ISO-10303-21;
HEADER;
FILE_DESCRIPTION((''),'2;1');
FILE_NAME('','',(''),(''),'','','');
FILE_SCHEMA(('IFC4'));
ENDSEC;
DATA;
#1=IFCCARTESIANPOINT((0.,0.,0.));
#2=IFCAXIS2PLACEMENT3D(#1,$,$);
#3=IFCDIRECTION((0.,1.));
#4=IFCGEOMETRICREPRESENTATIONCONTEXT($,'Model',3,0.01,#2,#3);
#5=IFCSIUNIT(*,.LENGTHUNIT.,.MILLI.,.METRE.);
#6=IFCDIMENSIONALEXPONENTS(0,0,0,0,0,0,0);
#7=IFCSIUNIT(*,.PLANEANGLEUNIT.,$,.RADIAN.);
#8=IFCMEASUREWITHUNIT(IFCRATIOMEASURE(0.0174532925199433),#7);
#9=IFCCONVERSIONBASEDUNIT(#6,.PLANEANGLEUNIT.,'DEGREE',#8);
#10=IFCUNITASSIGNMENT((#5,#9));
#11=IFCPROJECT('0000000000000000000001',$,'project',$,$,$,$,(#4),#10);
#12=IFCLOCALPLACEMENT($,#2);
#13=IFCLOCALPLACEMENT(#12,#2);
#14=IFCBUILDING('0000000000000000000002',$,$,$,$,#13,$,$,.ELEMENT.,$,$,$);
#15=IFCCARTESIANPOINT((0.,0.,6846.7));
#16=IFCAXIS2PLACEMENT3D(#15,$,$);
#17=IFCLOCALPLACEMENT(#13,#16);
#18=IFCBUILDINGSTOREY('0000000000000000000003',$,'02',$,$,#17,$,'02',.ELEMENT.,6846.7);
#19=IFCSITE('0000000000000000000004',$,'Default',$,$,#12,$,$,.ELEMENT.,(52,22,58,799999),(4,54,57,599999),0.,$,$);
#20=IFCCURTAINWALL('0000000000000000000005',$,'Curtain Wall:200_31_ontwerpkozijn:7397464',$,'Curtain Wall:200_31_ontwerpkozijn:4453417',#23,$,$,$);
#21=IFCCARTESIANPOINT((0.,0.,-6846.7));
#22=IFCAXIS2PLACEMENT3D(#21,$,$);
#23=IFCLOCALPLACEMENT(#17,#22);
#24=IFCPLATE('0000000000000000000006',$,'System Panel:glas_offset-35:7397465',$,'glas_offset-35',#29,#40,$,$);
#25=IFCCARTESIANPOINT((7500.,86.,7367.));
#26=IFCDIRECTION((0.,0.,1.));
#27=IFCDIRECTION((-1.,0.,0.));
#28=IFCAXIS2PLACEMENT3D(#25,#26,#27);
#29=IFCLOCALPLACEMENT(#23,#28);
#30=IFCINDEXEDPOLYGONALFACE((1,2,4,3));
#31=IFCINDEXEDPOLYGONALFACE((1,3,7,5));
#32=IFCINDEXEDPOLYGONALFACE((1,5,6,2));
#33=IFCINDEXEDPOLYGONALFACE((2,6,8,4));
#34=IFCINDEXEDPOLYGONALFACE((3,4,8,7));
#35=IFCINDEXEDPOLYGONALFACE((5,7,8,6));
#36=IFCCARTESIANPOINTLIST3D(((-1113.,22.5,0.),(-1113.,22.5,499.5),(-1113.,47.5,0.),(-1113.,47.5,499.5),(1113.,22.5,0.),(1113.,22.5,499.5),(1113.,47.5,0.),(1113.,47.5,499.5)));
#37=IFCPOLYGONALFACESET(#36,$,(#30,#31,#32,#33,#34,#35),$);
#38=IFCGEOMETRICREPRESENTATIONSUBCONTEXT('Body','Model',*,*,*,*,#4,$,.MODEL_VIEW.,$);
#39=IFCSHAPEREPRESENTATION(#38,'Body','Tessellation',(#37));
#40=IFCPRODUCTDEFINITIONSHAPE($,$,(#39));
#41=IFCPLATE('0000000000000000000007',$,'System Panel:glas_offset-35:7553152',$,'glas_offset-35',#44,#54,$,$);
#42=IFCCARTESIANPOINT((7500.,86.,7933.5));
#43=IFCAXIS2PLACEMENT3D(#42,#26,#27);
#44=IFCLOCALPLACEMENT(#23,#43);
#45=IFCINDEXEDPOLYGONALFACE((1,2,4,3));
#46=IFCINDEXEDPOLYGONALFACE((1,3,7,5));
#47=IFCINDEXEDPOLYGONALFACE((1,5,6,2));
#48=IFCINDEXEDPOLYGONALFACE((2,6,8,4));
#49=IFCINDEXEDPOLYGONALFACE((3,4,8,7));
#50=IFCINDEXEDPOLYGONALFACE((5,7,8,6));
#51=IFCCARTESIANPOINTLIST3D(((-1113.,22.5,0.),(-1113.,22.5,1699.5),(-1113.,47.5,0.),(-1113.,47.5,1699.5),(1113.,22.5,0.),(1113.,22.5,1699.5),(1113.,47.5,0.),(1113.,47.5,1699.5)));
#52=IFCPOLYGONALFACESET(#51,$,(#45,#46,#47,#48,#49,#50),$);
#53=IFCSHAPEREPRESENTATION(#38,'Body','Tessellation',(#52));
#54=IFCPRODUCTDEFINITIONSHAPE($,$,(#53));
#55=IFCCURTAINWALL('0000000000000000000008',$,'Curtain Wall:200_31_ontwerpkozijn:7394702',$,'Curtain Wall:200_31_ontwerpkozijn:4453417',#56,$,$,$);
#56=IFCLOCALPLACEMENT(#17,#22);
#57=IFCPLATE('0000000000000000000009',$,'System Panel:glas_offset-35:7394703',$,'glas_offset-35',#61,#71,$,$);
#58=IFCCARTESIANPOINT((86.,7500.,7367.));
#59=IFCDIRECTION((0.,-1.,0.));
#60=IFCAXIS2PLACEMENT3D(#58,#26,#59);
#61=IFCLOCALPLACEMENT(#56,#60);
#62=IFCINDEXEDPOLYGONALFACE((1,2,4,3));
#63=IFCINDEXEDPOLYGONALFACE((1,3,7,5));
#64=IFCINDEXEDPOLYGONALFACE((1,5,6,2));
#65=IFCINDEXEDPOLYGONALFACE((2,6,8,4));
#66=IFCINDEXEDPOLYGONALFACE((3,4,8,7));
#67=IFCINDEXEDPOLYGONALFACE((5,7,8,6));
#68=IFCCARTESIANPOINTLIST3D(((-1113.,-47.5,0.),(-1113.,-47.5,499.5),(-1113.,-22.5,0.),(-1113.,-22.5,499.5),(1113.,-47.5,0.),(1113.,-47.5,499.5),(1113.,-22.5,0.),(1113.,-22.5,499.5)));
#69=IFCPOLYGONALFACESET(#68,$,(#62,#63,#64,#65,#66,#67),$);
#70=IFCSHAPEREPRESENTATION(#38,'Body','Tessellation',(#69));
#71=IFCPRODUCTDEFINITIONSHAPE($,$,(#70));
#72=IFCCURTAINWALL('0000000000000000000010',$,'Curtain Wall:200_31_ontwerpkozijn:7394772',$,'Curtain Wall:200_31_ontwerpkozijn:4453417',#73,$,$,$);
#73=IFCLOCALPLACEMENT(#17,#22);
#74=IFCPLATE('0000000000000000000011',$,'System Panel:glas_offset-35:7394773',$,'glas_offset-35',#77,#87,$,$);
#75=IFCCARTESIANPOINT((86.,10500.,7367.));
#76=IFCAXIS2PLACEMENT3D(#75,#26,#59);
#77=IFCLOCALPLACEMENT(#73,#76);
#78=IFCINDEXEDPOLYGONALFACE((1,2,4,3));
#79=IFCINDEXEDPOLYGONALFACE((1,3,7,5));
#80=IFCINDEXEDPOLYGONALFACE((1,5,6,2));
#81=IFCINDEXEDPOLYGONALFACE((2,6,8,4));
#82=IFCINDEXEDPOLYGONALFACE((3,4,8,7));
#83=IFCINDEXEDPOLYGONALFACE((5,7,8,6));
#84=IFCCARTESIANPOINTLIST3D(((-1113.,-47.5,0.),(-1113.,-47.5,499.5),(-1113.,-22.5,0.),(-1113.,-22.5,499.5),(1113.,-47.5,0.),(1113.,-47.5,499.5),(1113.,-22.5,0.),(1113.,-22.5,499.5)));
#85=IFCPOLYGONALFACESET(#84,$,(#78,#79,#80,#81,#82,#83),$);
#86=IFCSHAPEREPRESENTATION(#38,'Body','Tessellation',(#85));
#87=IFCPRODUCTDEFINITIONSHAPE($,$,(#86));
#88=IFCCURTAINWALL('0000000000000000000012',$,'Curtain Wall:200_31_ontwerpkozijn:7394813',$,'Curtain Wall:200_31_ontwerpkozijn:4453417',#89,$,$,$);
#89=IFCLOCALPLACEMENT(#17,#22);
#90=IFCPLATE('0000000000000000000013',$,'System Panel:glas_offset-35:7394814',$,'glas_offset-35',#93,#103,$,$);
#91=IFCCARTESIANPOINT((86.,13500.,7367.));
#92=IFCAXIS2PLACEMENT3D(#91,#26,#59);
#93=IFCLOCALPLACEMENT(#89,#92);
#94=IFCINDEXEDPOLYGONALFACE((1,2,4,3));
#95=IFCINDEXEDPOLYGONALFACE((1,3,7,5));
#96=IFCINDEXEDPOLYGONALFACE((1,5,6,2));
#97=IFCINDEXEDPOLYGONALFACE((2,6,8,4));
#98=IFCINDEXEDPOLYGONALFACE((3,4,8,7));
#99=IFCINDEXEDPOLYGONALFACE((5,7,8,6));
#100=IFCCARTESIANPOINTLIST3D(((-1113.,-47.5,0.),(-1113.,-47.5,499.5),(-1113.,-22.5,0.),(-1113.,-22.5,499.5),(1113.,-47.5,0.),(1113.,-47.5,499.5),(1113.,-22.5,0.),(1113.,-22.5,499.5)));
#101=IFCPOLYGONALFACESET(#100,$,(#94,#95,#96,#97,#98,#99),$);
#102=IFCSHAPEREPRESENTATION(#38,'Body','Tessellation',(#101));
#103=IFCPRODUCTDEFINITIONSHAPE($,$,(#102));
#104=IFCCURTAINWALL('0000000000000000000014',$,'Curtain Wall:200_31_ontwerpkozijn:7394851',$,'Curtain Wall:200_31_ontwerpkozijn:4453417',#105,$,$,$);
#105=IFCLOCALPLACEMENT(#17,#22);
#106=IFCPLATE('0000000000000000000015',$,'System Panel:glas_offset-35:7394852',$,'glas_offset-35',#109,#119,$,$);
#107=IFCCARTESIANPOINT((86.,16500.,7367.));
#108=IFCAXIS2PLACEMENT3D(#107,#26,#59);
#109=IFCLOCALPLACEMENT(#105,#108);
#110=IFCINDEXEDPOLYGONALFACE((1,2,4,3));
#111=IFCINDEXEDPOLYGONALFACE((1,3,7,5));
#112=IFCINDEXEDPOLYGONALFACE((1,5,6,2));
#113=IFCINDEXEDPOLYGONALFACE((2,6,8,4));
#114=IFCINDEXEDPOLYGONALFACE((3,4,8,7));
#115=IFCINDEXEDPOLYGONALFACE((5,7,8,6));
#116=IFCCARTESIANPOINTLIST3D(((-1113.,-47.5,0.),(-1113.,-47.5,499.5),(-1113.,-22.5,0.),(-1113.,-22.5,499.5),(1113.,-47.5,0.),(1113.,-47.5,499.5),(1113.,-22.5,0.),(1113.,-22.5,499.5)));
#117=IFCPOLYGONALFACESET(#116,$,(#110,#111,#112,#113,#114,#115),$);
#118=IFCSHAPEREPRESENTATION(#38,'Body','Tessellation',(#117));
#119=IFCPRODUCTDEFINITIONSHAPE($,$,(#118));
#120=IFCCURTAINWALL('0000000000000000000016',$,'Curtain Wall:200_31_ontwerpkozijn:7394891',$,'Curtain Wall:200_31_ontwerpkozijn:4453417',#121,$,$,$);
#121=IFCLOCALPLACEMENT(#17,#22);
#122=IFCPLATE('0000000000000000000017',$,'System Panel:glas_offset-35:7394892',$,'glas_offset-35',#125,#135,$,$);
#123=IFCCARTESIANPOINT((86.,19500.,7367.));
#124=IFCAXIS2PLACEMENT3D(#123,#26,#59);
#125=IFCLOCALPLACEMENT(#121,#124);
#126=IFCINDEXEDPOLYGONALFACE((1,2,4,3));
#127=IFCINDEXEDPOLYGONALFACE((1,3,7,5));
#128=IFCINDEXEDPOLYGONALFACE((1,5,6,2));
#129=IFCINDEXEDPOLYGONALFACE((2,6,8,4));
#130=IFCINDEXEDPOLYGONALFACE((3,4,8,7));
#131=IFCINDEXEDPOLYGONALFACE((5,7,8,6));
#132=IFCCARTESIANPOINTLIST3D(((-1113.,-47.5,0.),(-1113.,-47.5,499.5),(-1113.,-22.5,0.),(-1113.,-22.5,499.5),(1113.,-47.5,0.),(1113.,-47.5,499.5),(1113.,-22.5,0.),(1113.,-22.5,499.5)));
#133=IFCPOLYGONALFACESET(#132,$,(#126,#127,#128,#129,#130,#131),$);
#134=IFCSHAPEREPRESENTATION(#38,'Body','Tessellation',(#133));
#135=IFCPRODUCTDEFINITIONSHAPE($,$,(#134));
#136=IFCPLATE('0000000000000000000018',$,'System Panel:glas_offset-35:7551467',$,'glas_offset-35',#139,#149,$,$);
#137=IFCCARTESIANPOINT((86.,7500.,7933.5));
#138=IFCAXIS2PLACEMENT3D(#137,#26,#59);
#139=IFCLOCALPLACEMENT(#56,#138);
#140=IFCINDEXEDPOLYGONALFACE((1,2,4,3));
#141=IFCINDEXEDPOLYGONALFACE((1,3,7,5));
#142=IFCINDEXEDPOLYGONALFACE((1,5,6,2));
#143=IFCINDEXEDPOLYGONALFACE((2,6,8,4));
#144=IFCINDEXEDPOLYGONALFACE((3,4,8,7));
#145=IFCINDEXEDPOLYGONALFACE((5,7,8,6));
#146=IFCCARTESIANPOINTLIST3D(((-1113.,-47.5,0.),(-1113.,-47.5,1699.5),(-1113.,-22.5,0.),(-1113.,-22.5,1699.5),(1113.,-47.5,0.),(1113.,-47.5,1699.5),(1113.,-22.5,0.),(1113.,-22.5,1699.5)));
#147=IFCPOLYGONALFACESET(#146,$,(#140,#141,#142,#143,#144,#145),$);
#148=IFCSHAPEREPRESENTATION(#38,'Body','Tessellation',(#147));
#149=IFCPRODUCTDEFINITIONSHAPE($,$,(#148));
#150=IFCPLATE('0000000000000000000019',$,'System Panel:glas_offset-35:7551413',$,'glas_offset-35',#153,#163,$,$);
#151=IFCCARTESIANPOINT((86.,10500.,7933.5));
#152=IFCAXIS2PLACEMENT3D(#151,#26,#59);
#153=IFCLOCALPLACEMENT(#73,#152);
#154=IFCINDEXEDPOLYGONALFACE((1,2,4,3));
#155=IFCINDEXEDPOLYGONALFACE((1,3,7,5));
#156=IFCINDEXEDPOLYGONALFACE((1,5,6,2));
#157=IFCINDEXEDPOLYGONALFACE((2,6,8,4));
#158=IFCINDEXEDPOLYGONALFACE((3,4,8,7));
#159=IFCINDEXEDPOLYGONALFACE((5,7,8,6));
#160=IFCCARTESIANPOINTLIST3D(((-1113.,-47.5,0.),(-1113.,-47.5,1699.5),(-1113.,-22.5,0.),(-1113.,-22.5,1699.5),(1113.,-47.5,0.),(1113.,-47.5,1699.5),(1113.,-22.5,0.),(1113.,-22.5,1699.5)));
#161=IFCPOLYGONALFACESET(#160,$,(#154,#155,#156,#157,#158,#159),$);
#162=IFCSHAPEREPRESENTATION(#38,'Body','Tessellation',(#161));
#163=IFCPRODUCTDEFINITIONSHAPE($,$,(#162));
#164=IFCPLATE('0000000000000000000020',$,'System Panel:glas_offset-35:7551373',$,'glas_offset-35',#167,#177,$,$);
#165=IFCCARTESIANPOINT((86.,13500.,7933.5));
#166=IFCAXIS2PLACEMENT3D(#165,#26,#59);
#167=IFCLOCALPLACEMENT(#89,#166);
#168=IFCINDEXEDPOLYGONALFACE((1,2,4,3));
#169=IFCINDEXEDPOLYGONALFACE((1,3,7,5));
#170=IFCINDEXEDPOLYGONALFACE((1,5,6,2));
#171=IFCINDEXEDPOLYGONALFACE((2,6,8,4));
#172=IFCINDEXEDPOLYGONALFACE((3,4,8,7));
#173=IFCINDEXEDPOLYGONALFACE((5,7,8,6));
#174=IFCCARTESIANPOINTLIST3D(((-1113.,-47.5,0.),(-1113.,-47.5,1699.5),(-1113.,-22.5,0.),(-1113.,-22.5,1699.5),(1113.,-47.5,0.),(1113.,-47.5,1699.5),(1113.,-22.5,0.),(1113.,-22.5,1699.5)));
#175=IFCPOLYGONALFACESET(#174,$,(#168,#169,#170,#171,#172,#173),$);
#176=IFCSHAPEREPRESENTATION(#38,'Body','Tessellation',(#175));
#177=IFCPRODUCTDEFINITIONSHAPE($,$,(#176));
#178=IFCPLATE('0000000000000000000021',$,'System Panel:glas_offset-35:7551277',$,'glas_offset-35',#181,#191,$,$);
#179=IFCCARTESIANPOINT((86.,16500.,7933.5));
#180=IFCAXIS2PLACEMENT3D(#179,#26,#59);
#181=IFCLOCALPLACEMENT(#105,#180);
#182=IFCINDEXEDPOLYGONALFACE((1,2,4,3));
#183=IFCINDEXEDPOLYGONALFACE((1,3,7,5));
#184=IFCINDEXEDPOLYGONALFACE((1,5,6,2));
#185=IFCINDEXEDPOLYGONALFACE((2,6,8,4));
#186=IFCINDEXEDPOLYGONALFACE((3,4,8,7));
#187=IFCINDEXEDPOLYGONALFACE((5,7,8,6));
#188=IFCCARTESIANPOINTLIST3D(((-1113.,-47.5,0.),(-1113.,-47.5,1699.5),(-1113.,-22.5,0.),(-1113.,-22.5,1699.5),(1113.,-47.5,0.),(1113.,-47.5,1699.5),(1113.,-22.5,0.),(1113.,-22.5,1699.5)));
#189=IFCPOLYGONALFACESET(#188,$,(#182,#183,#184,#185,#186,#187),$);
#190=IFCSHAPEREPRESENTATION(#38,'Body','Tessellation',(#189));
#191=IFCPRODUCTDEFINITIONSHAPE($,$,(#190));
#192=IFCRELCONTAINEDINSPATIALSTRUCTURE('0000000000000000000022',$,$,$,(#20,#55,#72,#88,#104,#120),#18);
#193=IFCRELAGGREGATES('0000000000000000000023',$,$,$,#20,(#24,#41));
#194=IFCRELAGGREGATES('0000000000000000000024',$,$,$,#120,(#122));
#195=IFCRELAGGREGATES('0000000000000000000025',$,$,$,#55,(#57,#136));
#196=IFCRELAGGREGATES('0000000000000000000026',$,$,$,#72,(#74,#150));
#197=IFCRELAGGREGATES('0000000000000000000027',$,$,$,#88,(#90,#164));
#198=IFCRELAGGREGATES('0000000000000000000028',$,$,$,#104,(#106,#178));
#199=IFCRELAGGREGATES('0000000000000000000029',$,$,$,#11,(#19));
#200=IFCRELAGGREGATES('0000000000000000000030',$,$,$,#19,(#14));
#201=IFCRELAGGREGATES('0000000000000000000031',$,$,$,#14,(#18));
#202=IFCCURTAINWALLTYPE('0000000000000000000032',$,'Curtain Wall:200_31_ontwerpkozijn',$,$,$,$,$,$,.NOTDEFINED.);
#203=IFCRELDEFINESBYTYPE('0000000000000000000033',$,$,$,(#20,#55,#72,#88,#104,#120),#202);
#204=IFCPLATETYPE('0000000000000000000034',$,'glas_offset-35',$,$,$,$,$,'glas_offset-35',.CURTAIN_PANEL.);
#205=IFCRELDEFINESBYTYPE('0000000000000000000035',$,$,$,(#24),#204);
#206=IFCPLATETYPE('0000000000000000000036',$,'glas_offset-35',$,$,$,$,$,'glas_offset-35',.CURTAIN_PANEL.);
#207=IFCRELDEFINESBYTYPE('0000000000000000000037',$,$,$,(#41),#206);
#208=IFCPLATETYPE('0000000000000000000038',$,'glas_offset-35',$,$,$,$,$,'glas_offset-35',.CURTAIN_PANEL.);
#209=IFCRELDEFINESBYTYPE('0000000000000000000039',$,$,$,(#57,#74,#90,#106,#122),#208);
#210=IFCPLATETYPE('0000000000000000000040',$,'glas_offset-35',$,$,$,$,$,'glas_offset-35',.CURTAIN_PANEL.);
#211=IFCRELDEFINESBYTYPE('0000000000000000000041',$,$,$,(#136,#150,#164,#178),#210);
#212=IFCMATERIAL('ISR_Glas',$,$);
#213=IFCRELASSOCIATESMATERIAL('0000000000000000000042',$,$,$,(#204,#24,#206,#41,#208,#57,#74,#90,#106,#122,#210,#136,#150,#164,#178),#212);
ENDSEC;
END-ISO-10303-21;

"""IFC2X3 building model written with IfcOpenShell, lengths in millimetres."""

from ifc_helpers import new_model, entity, si_unit, converted_unit, direction, frame, frame_2d, origin, origin_2d_with_axis, place, context, subcontext, project, spatial, rectangle, extrude, source, transform, mapped, material, type_object, type_shapes, element, aggregate, save


model = new_model("IFC2X3")

# Units and contexts
model_context = context("Model", 3, precision=0.01, world=origin(), true_north=direction((0.0, 1.0)))
body_context = subcontext(model_context, "Body", "Model", "MODEL_VIEW")
ifc_project = project(units=[si_unit("LENGTHUNIT", "METRE", prefix="MILLI"), converted_unit("PLANEANGLEUNIT", "DEGREE", entity("IfcRatioMeasure", 0.0174532925199433), si_unit("PLANEANGLEUNIT", "RADIAN"), dimensions=[0, 0, 0, 0, 0, 0, 0])], contexts=[model_context])

# Site, building, storey
site_placement = place(None, origin())
site = spatial("IfcSite", under=ifc_project, at=site_placement, Name="Default", CompositionType="ELEMENT", RefLatitude=(52, 22, 58, 799999), RefLongitude=(4, 54, 57, 599999), RefElevation=0.0)
building_placement = place(site_placement, origin())
building = spatial("IfcBuilding", under=site, at=building_placement, CompositionType="ELEMENT")
storey_placement = place(building_placement, frame((0.0, 0.0, 6846.7)))
storey = spatial("IfcBuildingStorey", under=building, at=storey_placement, Name="02", LongName="02", CompositionType="ELEMENT", Elevation=6846.7)

# Curtain wall, plates
curtain_wall_type = type_object("IfcCurtainWallType", Name="Curtain Wall:200_31_ontwerpkozijn", PredefinedType="NOTDEFINED")
curtain_wall_1_placement = place(storey_placement, frame((0.0, 0.0, -6846.7)))
curtain_wall_1 = element("IfcCurtainWall", 1, at=curtain_wall_1_placement, inside=storey, type_object=curtain_wall_type, Name="Curtain Wall:200_31_ontwerpkozijn:7397464", ObjectType="Curtain Wall:200_31_ontwerpkozijn:4453417")
ifc_material_1 = material(Name="ISR_Glas")
plate_type_1 = type_object("IfcPlateType", Name="glas_offset-35", ElementType="glas_offset-35", PredefinedType="CURTAIN_PANEL", material=ifc_material_1)
shared_shape_1 = source(origin(), body_context, "Body", "SweptSolid", [
    extrude(rectangle(XDim=25.0, YDim=2226.0, at=origin_2d_with_axis()), frame((0.0, 35.0, 0.0), z_axis=(0.0, 0.0, 1.0), x_axis=(0.0, 1.0, 0.0)), (0.0, 0.0, 1.0), 499.5),
])
type_shapes(plate_type_1, [shared_shape_1])
plate_1_placement = place(curtain_wall_1_placement, frame((7500.0, 86.0, 7367.0), z_axis=(0.0, 0.0, 1.0), x_axis=(-1.0, 0.0, 0.0)))
plate_1 = element("IfcPlate", 2, at=plate_1_placement, type_object=plate_type_1, material=ifc_material_1, Name="System Panel:glas_offset-35:7397465", ObjectType="glas_offset-35", context=body_context, shape_type="MappedRepresentation", body=[
    mapped(shared_shape_1, transform((0.0, 0.0, 0.0), scale=1.0)),
])
plate_type_2 = type_object("IfcPlateType", Name="glas_offset-35", ElementType="glas_offset-35", PredefinedType="CURTAIN_PANEL", material=ifc_material_1)
shared_shape_2 = source(origin(), body_context, "Body", "SweptSolid", [
    extrude(rectangle(XDim=25.0, YDim=2226.0, at=origin_2d_with_axis()), frame((0.0, 35.0, 0.0), z_axis=(0.0, 0.0, 1.0), x_axis=(0.0, 1.0, 0.0)), (0.0, 0.0, 1.0), 1699.5),
])
type_shapes(plate_type_2, [shared_shape_2])
plate_2_placement = place(curtain_wall_1_placement, frame((7500.0, 86.0, 7933.5), z_axis=(0.0, 0.0, 1.0), x_axis=(-1.0, 0.0, 0.0)))
plate_2 = element("IfcPlate", 3, at=plate_2_placement, type_object=plate_type_2, material=ifc_material_1, Name="System Panel:glas_offset-35:7553152", ObjectType="glas_offset-35", context=body_context, shape_type="MappedRepresentation", body=[
    mapped(shared_shape_2, transform((0.0, 0.0, 0.0), scale=1.0)),
])
aggregate(curtain_wall_1, [plate_1, plate_2])

# Curtain walls, plates
curtain_wall_2_placement = place(storey_placement, frame((0.0, 0.0, -6846.7)))
curtain_wall_2 = element("IfcCurtainWall", 4, at=curtain_wall_2_placement, inside=storey, type_object=curtain_wall_type, Name="Curtain Wall:200_31_ontwerpkozijn:7394702", ObjectType="Curtain Wall:200_31_ontwerpkozijn:4453417")
plate_type_3 = type_object("IfcPlateType", Name="glas_offset-35", ElementType="glas_offset-35", PredefinedType="CURTAIN_PANEL", material=ifc_material_1)
shared_shape_3 = source(origin(), body_context, "Body", "SweptSolid", [
    extrude(rectangle(XDim=25.0, YDim=2226.0, at=frame_2d((0.0, 0.0), x_axis=(1.0, 0.0))), frame((0.0, -35.0, 0.0), z_axis=(0.0, 0.0, 1.0), x_axis=(0.0, 1.0, 0.0)), (0.0, 0.0, 1.0), 499.5),
])
type_shapes(plate_type_3, [shared_shape_3])
plate_3_placement = place(curtain_wall_2_placement, frame((86.0, 7500.0, 7367.0), z_axis=(0.0, 0.0, 1.0), x_axis=(0.0, -1.0, 0.0)))
plate_3 = element("IfcPlate", 5, at=plate_3_placement, type_object=plate_type_3, material=ifc_material_1, Name="System Panel:glas_offset-35:7394703", ObjectType="glas_offset-35", context=body_context, shape_type="MappedRepresentation", body=[
    mapped(shared_shape_3, transform((0.0, 0.0, 0.0), scale=1.0)),
])
curtain_wall_3_placement = place(storey_placement, frame((0.0, 0.0, -6846.7)))
curtain_wall_3 = element("IfcCurtainWall", 6, at=curtain_wall_3_placement, inside=storey, type_object=curtain_wall_type, Name="Curtain Wall:200_31_ontwerpkozijn:7394772", ObjectType="Curtain Wall:200_31_ontwerpkozijn:4453417")
plate_4_placement = place(curtain_wall_3_placement, frame((86.0, 10500.0, 7367.0), z_axis=(0.0, 0.0, 1.0), x_axis=(0.0, -1.0, 0.0)))
plate_4 = element("IfcPlate", 7, at=plate_4_placement, type_object=plate_type_3, material=ifc_material_1, Name="System Panel:glas_offset-35:7394773", ObjectType="glas_offset-35", context=body_context, shape_type="MappedRepresentation", body=[
    mapped(shared_shape_3, transform((0.0, 0.0, 0.0), scale=1.0)),
])
curtain_wall_4_placement = place(storey_placement, frame((0.0, 0.0, -6846.7)))
curtain_wall_4 = element("IfcCurtainWall", 8, at=curtain_wall_4_placement, inside=storey, type_object=curtain_wall_type, Name="Curtain Wall:200_31_ontwerpkozijn:7394813", ObjectType="Curtain Wall:200_31_ontwerpkozijn:4453417")
plate_5_placement = place(curtain_wall_4_placement, frame((86.0, 13500.0, 7367.0), z_axis=(0.0, 0.0, 1.0), x_axis=(0.0, -1.0, 0.0)))
plate_5 = element("IfcPlate", 9, at=plate_5_placement, type_object=plate_type_3, material=ifc_material_1, Name="System Panel:glas_offset-35:7394814", ObjectType="glas_offset-35", context=body_context, shape_type="MappedRepresentation", body=[
    mapped(shared_shape_3, transform((0.0, 0.0, 0.0), scale=1.0)),
])
curtain_wall_5_placement = place(storey_placement, frame((0.0, 0.0, -6846.7)))
curtain_wall_5 = element("IfcCurtainWall", 10, at=curtain_wall_5_placement, inside=storey, type_object=curtain_wall_type, Name="Curtain Wall:200_31_ontwerpkozijn:7394851", ObjectType="Curtain Wall:200_31_ontwerpkozijn:4453417")
plate_6_placement = place(curtain_wall_5_placement, frame((86.0, 16500.0, 7367.0), z_axis=(0.0, 0.0, 1.0), x_axis=(0.0, -1.0, 0.0)))
plate_6 = element("IfcPlate", 11, at=plate_6_placement, type_object=plate_type_3, material=ifc_material_1, Name="System Panel:glas_offset-35:7394852", ObjectType="glas_offset-35", context=body_context, shape_type="MappedRepresentation", body=[
    mapped(shared_shape_3, transform((0.0, 0.0, 0.0), scale=1.0)),
])
curtain_wall_6_placement = place(storey_placement, frame((0.0, 0.0, -6846.7)))
curtain_wall_6 = element("IfcCurtainWall", 12, at=curtain_wall_6_placement, inside=storey, type_object=curtain_wall_type, Name="Curtain Wall:200_31_ontwerpkozijn:7394891", ObjectType="Curtain Wall:200_31_ontwerpkozijn:4453417")
plate_7_placement = place(curtain_wall_6_placement, frame((86.0, 19500.0, 7367.0), z_axis=(0.0, 0.0, 1.0), x_axis=(0.0, -1.0, 0.0)))
plate_7 = element("IfcPlate", 13, at=plate_7_placement, type_object=plate_type_3, material=ifc_material_1, Name="System Panel:glas_offset-35:7394892", ObjectType="glas_offset-35", context=body_context, shape_type="MappedRepresentation", body=[
    mapped(shared_shape_3, transform((0.0, 0.0, 0.0), scale=1.0)),
])
aggregate(curtain_wall_6, [plate_7])

# Plates
plate_type_4 = type_object("IfcPlateType", Name="glas_offset-35", ElementType="glas_offset-35", PredefinedType="CURTAIN_PANEL", material=ifc_material_1)
shared_shape_4 = source(origin(), body_context, "Body", "SweptSolid", [
    extrude(rectangle(XDim=25.0, YDim=2226.0, at=frame_2d((0.0, 0.0), x_axis=(1.0, 0.0))), frame((0.0, -35.0, 0.0), z_axis=(0.0, 0.0, 1.0), x_axis=(0.0, 1.0, 0.0)), (0.0, 0.0, 1.0), 1699.5),
])
type_shapes(plate_type_4, [shared_shape_4])
plate_8_placement = place(curtain_wall_2_placement, frame((86.0, 7500.0, 7933.5), z_axis=(0.0, 0.0, 1.0), x_axis=(0.0, -1.0, 0.0)))
plate_8 = element("IfcPlate", 14, at=plate_8_placement, type_object=plate_type_4, material=ifc_material_1, Name="System Panel:glas_offset-35:7551467", ObjectType="glas_offset-35", context=body_context, shape_type="MappedRepresentation", body=[
    mapped(shared_shape_4, transform((0.0, 0.0, 0.0), scale=1.0)),
])
aggregate(curtain_wall_2, [plate_3, plate_8])
plate_9_placement = place(curtain_wall_3_placement, frame((86.0, 10500.0, 7933.5), z_axis=(0.0, 0.0, 1.0), x_axis=(0.0, -1.0, 0.0)))
plate_9 = element("IfcPlate", 15, at=plate_9_placement, type_object=plate_type_4, material=ifc_material_1, Name="System Panel:glas_offset-35:7551413", ObjectType="glas_offset-35", context=body_context, shape_type="MappedRepresentation", body=[
    mapped(shared_shape_4, transform((0.0, 0.0, 0.0), scale=1.0)),
])
aggregate(curtain_wall_3, [plate_4, plate_9])
plate_10_placement = place(curtain_wall_4_placement, frame((86.0, 13500.0, 7933.5), z_axis=(0.0, 0.0, 1.0), x_axis=(0.0, -1.0, 0.0)))
plate_10 = element("IfcPlate", 16, at=plate_10_placement, type_object=plate_type_4, material=ifc_material_1, Name="System Panel:glas_offset-35:7551373", ObjectType="glas_offset-35", context=body_context, shape_type="MappedRepresentation", body=[
    mapped(shared_shape_4, transform((0.0, 0.0, 0.0), scale=1.0)),
])
aggregate(curtain_wall_4, [plate_5, plate_10])
plate_11_placement = place(curtain_wall_5_placement, frame((86.0, 16500.0, 7933.5), z_axis=(0.0, 0.0, 1.0), x_axis=(0.0, -1.0, 0.0)))
plate_11 = element("IfcPlate", 17, at=plate_11_placement, type_object=plate_type_4, material=ifc_material_1, Name="System Panel:glas_offset-35:7551277", ObjectType="glas_offset-35", context=body_context, shape_type="MappedRepresentation", body=[
    mapped(shared_shape_4, transform((0.0, 0.0, 0.0), scale=1.0)),
])
aggregate(curtain_wall_5, [plate_6, plate_11])

save(model, "model.ifc")
